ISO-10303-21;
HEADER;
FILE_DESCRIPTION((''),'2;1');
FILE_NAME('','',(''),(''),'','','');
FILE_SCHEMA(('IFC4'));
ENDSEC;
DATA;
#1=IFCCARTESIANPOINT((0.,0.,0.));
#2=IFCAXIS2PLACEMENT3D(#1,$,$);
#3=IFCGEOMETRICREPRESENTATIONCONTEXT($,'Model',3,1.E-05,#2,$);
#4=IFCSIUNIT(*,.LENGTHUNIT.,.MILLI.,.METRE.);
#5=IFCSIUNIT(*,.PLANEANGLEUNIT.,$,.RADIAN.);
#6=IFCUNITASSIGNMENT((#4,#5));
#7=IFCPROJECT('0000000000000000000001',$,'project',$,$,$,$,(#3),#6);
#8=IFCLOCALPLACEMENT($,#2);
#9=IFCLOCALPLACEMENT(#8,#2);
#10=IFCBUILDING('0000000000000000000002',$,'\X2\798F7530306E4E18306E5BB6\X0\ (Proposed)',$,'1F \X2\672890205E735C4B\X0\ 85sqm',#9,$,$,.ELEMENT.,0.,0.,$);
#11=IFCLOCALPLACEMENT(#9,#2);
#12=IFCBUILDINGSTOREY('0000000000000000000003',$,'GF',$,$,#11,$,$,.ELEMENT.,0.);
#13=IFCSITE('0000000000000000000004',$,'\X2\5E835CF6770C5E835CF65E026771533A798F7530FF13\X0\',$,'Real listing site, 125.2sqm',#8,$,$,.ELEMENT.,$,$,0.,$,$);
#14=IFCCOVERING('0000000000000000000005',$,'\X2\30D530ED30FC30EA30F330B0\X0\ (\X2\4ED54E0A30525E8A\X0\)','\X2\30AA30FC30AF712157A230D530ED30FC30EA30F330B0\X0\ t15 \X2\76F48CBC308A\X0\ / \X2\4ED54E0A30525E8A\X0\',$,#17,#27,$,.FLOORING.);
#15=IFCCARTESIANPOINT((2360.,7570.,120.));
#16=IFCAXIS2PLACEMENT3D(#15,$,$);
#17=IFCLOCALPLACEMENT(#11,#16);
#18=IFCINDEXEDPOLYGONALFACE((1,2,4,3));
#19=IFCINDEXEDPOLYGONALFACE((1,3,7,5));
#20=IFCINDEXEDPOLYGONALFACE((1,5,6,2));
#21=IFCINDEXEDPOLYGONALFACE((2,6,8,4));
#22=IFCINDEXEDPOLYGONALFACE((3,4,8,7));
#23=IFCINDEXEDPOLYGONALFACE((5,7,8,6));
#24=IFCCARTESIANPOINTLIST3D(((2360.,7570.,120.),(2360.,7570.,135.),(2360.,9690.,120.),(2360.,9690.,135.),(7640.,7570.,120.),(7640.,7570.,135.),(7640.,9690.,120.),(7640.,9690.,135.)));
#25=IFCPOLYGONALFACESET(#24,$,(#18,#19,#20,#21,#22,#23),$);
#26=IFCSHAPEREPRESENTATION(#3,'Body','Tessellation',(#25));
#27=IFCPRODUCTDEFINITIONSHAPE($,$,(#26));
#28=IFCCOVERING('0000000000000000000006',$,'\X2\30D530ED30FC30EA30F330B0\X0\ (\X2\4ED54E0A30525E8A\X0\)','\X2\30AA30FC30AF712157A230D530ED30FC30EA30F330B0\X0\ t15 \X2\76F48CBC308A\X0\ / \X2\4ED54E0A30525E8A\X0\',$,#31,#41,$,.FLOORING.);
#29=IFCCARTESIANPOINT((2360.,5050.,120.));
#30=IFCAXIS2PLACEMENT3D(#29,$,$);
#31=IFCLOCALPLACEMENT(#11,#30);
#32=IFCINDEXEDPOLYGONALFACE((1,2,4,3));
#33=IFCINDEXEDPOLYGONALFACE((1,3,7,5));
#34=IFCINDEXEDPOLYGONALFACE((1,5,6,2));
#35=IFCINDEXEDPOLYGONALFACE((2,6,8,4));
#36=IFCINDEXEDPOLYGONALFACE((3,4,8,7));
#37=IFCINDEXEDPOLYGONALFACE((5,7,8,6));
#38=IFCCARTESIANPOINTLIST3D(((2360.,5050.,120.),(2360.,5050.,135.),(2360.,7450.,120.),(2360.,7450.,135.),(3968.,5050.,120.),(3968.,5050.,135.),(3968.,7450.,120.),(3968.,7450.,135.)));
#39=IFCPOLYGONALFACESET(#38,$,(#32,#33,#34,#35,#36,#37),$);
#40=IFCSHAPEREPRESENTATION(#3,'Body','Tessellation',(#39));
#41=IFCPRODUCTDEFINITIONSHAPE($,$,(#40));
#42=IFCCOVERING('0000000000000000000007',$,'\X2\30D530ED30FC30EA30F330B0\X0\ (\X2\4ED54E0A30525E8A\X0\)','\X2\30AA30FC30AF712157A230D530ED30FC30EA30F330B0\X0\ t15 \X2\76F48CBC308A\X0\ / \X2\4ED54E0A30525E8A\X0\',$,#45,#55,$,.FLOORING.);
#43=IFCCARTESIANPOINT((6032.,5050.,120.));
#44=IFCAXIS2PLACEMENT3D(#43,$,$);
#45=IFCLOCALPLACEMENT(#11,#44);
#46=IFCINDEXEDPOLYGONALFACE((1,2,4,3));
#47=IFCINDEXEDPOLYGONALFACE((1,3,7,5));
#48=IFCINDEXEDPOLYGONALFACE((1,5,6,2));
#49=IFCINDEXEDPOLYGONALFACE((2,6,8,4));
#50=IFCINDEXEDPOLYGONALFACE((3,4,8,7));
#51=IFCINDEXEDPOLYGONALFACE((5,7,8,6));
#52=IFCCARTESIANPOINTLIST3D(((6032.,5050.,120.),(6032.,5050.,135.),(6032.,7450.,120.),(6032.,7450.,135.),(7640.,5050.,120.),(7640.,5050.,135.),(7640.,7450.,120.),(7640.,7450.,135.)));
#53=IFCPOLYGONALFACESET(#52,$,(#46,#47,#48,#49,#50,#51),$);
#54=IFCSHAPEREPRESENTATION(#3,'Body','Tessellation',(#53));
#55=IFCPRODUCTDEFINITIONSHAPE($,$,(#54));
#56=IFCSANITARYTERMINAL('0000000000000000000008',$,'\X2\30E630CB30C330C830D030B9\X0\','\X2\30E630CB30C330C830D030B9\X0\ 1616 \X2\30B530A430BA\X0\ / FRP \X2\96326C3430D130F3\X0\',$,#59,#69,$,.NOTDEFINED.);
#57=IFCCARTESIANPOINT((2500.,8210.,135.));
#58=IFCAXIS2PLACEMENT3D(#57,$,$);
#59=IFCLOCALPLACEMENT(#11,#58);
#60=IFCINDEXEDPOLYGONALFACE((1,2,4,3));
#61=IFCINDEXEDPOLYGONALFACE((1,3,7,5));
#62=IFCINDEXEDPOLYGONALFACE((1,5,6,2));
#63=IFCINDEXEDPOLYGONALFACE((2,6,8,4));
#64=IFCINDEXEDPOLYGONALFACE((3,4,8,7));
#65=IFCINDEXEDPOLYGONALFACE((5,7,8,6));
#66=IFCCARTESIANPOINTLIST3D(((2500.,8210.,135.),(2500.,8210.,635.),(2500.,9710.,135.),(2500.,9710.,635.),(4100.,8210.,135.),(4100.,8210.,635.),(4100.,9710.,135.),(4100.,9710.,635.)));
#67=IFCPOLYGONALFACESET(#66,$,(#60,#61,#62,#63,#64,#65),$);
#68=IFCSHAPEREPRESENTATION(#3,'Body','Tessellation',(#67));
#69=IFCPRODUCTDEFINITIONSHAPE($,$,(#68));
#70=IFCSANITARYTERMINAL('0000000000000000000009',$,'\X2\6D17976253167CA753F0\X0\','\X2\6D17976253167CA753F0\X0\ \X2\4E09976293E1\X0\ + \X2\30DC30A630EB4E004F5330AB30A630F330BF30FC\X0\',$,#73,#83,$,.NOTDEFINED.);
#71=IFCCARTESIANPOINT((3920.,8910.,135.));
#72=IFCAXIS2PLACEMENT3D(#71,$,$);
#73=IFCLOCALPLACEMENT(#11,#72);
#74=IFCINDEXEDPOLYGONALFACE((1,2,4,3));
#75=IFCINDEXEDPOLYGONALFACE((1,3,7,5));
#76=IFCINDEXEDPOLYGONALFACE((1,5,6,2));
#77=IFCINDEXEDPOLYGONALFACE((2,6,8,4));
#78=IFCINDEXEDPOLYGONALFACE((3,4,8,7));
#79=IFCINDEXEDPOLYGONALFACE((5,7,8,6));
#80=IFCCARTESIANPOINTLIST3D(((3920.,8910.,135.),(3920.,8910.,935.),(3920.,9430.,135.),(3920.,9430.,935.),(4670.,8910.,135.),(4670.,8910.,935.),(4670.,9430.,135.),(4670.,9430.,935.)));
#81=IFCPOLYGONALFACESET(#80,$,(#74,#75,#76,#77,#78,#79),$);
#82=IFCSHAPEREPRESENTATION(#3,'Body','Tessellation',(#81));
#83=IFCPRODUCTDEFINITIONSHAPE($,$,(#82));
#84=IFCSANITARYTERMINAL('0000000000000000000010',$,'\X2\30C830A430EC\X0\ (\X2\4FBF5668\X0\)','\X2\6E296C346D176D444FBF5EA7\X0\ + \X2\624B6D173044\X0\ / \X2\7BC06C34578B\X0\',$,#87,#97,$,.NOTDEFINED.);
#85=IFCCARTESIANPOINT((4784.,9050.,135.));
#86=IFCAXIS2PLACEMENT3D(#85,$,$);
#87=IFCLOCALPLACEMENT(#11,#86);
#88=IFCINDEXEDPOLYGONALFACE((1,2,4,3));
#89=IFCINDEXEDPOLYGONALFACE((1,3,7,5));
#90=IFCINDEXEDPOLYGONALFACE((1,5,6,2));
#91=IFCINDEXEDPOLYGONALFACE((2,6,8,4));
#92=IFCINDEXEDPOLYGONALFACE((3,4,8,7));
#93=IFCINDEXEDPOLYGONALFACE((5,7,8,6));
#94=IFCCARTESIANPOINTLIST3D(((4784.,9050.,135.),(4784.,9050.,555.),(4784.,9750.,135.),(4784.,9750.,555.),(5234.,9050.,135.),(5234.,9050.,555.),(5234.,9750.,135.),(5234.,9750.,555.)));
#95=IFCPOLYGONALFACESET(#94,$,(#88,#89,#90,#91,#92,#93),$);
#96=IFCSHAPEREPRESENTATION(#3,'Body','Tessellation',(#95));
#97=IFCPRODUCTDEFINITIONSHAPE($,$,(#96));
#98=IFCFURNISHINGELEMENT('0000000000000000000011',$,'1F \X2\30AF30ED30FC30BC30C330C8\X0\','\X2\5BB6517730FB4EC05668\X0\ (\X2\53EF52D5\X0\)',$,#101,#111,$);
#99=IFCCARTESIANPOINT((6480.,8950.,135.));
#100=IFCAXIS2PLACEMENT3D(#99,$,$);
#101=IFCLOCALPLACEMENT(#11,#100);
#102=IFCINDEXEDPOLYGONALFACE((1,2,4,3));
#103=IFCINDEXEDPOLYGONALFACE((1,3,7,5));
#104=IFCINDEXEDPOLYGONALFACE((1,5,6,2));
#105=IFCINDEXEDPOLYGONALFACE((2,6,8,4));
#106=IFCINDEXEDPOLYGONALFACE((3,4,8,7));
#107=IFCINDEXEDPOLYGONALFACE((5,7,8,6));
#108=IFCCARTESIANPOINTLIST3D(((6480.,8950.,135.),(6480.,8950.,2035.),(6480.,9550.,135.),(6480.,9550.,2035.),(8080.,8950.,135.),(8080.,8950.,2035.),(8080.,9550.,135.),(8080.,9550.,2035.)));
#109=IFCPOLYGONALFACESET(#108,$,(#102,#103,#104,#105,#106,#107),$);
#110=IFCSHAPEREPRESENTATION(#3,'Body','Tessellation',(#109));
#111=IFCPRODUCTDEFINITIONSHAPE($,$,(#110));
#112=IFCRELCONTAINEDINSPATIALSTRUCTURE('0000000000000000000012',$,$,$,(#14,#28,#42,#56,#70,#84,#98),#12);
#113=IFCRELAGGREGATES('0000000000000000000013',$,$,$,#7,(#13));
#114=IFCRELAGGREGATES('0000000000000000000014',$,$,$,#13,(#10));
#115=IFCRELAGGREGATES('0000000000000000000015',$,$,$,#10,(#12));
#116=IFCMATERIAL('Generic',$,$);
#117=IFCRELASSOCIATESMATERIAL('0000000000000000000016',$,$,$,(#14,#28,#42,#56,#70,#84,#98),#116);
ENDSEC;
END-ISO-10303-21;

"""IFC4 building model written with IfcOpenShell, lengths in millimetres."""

from ifc_helpers import new_model, si_unit, frame, frame_2d, origin, place, context, project, spatial, rectangle, extrude, material, element, save


model = new_model("IFC4")

# Units and contexts
model_context = context("Model", 3, precision=1e-05, world=origin())
ifc_project = project(units=[si_unit("LENGTHUNIT", "METRE", prefix="MILLI"), si_unit("PLANEANGLEUNIT", "RADIAN")], contexts=[model_context])

# Site, building, storey
site_placement = place(None, origin())
site = spatial("IfcSite", under=ifc_project, at=site_placement, Name="広島県広島市東区福田３", ObjectType="Real listing site, 125.2sqm", CompositionType="ELEMENT", RefElevation=0.0)
building_placement = place(site_placement, origin())
building = spatial("IfcBuilding", under=site, at=building_placement, Name="福田の丘の家 (Proposed)", ObjectType="1F 木造平屋 85sqm", CompositionType="ELEMENT", ElevationOfRefHeight=0.0, ElevationOfTerrain=0.0)
storey_placement = place(building_placement, origin())
storey = spatial("IfcBuildingStorey", under=building, at=storey_placement, Name="GF", CompositionType="ELEMENT", Elevation=0.0)

# Coverings
ifc_material_1 = material(Name="Generic")
covering_1_placement = place(storey_placement, frame((2360.0, 7570.0, 120.0)))
element("IfcCovering", 1, at=covering_1_placement, inside=storey, material=ifc_material_1, Name="フローリング (仕上げ床)", Description="オーク無垢フローリング t15 直貼り / 仕上げ床", PredefinedType="FLOORING", context=model_context, shape_type="SweptSolid", body=[
    extrude(rectangle(XDim=5280.0, YDim=2120.0, at=frame_2d((2640.0, 1060.0))), frame((2360.0, 7570.0, 120.0)), (0.0, 0.0, 1.0), 15.0),
])
covering_2_placement = place(storey_placement, frame((2360.0, 5050.0, 120.0)))
element("IfcCovering", 2, at=covering_2_placement, inside=storey, material=ifc_material_1, Name="フローリング (仕上げ床)", Description="オーク無垢フローリング t15 直貼り / 仕上げ床", PredefinedType="FLOORING", context=model_context, shape_type="SweptSolid", body=[
    extrude(rectangle(XDim=1608.0, YDim=2400.0, at=frame_2d((804.0, 1200.0))), frame((2360.0, 5050.0, 120.0)), (0.0, 0.0, 1.0), 15.0),
])
covering_3_placement = place(storey_placement, frame((6032.0, 5050.0, 120.0)))
element("IfcCovering", 3, at=covering_3_placement, inside=storey, material=ifc_material_1, Name="フローリング (仕上げ床)", Description="オーク無垢フローリング t15 直貼り / 仕上げ床", PredefinedType="FLOORING", context=model_context, shape_type="SweptSolid", body=[
    extrude(rectangle(XDim=1608.0, YDim=2400.0, at=frame_2d((804.0, 1200.0))), frame((6032.0, 5050.0, 120.0)), (0.0, 0.0, 1.0), 15.0),
])

# Sanitary terminals
sanitary_terminal_1_placement = place(storey_placement, frame((2500.0, 8210.0, 135.0)))
element("IfcSanitaryTerminal", 4, at=sanitary_terminal_1_placement, inside=storey, material=ifc_material_1, Name="ユニットバス", Description="ユニットバス 1616 サイズ / FRP 防水パン", PredefinedType="NOTDEFINED", context=model_context, shape_type="SweptSolid", body=[
    extrude(rectangle(XDim=1600.0, YDim=1500.0, at=frame_2d((800.0, 750.0))), frame((2500.0, 8210.0, 135.0)), (0.0, 0.0, 1.0), 500.0),
])
sanitary_terminal_2_placement = place(storey_placement, frame((3920.0, 8910.0, 135.0)))
element("IfcSanitaryTerminal", 5, at=sanitary_terminal_2_placement, inside=storey, material=ifc_material_1, Name="洗面化粧台", Description="洗面化粧台 三面鏡 + ボウル一体カウンター", PredefinedType="NOTDEFINED", context=model_context, shape_type="SweptSolid", body=[
    extrude(rectangle(XDim=750.0, YDim=520.0, at=frame_2d((375.0, 260.0))), frame((3920.0, 8910.0, 135.0)), (0.0, 0.0, 1.0), 800.0),
])
sanitary_terminal_3_placement = place(storey_placement, frame((4784.0, 9050.0, 135.0)))
element("IfcSanitaryTerminal", 6, at=sanitary_terminal_3_placement, inside=storey, material=ifc_material_1, Name="トイレ (便器)", Description="温水洗浄便座 + 手洗い / 節水型", PredefinedType="NOTDEFINED", context=model_context, shape_type="SweptSolid", body=[
    extrude(rectangle(XDim=450.0, YDim=700.0, at=frame_2d((225.0, 350.0))), frame((4784.0, 9050.0, 135.0)), (0.0, 0.0, 1.0), 420.0),
])

# Furnishing element
furnishing_placement = place(storey_placement, frame((6480.0, 8950.0, 135.0)))
element("IfcFurnishingElement", 7, at=furnishing_placement, inside=storey, material=ifc_material_1, Name="1F クローゼット", Description="家具・什器 (可動)", context=model_context, shape_type="SweptSolid", body=[
    extrude(rectangle(XDim=1600.0, YDim=600.0, at=frame_2d((800.0, 300.0))), frame((6480.0, 8950.0, 135.0)), (0.0, 0.0, 1.0), 1900.0),
])

save(model, "model.ifc")
